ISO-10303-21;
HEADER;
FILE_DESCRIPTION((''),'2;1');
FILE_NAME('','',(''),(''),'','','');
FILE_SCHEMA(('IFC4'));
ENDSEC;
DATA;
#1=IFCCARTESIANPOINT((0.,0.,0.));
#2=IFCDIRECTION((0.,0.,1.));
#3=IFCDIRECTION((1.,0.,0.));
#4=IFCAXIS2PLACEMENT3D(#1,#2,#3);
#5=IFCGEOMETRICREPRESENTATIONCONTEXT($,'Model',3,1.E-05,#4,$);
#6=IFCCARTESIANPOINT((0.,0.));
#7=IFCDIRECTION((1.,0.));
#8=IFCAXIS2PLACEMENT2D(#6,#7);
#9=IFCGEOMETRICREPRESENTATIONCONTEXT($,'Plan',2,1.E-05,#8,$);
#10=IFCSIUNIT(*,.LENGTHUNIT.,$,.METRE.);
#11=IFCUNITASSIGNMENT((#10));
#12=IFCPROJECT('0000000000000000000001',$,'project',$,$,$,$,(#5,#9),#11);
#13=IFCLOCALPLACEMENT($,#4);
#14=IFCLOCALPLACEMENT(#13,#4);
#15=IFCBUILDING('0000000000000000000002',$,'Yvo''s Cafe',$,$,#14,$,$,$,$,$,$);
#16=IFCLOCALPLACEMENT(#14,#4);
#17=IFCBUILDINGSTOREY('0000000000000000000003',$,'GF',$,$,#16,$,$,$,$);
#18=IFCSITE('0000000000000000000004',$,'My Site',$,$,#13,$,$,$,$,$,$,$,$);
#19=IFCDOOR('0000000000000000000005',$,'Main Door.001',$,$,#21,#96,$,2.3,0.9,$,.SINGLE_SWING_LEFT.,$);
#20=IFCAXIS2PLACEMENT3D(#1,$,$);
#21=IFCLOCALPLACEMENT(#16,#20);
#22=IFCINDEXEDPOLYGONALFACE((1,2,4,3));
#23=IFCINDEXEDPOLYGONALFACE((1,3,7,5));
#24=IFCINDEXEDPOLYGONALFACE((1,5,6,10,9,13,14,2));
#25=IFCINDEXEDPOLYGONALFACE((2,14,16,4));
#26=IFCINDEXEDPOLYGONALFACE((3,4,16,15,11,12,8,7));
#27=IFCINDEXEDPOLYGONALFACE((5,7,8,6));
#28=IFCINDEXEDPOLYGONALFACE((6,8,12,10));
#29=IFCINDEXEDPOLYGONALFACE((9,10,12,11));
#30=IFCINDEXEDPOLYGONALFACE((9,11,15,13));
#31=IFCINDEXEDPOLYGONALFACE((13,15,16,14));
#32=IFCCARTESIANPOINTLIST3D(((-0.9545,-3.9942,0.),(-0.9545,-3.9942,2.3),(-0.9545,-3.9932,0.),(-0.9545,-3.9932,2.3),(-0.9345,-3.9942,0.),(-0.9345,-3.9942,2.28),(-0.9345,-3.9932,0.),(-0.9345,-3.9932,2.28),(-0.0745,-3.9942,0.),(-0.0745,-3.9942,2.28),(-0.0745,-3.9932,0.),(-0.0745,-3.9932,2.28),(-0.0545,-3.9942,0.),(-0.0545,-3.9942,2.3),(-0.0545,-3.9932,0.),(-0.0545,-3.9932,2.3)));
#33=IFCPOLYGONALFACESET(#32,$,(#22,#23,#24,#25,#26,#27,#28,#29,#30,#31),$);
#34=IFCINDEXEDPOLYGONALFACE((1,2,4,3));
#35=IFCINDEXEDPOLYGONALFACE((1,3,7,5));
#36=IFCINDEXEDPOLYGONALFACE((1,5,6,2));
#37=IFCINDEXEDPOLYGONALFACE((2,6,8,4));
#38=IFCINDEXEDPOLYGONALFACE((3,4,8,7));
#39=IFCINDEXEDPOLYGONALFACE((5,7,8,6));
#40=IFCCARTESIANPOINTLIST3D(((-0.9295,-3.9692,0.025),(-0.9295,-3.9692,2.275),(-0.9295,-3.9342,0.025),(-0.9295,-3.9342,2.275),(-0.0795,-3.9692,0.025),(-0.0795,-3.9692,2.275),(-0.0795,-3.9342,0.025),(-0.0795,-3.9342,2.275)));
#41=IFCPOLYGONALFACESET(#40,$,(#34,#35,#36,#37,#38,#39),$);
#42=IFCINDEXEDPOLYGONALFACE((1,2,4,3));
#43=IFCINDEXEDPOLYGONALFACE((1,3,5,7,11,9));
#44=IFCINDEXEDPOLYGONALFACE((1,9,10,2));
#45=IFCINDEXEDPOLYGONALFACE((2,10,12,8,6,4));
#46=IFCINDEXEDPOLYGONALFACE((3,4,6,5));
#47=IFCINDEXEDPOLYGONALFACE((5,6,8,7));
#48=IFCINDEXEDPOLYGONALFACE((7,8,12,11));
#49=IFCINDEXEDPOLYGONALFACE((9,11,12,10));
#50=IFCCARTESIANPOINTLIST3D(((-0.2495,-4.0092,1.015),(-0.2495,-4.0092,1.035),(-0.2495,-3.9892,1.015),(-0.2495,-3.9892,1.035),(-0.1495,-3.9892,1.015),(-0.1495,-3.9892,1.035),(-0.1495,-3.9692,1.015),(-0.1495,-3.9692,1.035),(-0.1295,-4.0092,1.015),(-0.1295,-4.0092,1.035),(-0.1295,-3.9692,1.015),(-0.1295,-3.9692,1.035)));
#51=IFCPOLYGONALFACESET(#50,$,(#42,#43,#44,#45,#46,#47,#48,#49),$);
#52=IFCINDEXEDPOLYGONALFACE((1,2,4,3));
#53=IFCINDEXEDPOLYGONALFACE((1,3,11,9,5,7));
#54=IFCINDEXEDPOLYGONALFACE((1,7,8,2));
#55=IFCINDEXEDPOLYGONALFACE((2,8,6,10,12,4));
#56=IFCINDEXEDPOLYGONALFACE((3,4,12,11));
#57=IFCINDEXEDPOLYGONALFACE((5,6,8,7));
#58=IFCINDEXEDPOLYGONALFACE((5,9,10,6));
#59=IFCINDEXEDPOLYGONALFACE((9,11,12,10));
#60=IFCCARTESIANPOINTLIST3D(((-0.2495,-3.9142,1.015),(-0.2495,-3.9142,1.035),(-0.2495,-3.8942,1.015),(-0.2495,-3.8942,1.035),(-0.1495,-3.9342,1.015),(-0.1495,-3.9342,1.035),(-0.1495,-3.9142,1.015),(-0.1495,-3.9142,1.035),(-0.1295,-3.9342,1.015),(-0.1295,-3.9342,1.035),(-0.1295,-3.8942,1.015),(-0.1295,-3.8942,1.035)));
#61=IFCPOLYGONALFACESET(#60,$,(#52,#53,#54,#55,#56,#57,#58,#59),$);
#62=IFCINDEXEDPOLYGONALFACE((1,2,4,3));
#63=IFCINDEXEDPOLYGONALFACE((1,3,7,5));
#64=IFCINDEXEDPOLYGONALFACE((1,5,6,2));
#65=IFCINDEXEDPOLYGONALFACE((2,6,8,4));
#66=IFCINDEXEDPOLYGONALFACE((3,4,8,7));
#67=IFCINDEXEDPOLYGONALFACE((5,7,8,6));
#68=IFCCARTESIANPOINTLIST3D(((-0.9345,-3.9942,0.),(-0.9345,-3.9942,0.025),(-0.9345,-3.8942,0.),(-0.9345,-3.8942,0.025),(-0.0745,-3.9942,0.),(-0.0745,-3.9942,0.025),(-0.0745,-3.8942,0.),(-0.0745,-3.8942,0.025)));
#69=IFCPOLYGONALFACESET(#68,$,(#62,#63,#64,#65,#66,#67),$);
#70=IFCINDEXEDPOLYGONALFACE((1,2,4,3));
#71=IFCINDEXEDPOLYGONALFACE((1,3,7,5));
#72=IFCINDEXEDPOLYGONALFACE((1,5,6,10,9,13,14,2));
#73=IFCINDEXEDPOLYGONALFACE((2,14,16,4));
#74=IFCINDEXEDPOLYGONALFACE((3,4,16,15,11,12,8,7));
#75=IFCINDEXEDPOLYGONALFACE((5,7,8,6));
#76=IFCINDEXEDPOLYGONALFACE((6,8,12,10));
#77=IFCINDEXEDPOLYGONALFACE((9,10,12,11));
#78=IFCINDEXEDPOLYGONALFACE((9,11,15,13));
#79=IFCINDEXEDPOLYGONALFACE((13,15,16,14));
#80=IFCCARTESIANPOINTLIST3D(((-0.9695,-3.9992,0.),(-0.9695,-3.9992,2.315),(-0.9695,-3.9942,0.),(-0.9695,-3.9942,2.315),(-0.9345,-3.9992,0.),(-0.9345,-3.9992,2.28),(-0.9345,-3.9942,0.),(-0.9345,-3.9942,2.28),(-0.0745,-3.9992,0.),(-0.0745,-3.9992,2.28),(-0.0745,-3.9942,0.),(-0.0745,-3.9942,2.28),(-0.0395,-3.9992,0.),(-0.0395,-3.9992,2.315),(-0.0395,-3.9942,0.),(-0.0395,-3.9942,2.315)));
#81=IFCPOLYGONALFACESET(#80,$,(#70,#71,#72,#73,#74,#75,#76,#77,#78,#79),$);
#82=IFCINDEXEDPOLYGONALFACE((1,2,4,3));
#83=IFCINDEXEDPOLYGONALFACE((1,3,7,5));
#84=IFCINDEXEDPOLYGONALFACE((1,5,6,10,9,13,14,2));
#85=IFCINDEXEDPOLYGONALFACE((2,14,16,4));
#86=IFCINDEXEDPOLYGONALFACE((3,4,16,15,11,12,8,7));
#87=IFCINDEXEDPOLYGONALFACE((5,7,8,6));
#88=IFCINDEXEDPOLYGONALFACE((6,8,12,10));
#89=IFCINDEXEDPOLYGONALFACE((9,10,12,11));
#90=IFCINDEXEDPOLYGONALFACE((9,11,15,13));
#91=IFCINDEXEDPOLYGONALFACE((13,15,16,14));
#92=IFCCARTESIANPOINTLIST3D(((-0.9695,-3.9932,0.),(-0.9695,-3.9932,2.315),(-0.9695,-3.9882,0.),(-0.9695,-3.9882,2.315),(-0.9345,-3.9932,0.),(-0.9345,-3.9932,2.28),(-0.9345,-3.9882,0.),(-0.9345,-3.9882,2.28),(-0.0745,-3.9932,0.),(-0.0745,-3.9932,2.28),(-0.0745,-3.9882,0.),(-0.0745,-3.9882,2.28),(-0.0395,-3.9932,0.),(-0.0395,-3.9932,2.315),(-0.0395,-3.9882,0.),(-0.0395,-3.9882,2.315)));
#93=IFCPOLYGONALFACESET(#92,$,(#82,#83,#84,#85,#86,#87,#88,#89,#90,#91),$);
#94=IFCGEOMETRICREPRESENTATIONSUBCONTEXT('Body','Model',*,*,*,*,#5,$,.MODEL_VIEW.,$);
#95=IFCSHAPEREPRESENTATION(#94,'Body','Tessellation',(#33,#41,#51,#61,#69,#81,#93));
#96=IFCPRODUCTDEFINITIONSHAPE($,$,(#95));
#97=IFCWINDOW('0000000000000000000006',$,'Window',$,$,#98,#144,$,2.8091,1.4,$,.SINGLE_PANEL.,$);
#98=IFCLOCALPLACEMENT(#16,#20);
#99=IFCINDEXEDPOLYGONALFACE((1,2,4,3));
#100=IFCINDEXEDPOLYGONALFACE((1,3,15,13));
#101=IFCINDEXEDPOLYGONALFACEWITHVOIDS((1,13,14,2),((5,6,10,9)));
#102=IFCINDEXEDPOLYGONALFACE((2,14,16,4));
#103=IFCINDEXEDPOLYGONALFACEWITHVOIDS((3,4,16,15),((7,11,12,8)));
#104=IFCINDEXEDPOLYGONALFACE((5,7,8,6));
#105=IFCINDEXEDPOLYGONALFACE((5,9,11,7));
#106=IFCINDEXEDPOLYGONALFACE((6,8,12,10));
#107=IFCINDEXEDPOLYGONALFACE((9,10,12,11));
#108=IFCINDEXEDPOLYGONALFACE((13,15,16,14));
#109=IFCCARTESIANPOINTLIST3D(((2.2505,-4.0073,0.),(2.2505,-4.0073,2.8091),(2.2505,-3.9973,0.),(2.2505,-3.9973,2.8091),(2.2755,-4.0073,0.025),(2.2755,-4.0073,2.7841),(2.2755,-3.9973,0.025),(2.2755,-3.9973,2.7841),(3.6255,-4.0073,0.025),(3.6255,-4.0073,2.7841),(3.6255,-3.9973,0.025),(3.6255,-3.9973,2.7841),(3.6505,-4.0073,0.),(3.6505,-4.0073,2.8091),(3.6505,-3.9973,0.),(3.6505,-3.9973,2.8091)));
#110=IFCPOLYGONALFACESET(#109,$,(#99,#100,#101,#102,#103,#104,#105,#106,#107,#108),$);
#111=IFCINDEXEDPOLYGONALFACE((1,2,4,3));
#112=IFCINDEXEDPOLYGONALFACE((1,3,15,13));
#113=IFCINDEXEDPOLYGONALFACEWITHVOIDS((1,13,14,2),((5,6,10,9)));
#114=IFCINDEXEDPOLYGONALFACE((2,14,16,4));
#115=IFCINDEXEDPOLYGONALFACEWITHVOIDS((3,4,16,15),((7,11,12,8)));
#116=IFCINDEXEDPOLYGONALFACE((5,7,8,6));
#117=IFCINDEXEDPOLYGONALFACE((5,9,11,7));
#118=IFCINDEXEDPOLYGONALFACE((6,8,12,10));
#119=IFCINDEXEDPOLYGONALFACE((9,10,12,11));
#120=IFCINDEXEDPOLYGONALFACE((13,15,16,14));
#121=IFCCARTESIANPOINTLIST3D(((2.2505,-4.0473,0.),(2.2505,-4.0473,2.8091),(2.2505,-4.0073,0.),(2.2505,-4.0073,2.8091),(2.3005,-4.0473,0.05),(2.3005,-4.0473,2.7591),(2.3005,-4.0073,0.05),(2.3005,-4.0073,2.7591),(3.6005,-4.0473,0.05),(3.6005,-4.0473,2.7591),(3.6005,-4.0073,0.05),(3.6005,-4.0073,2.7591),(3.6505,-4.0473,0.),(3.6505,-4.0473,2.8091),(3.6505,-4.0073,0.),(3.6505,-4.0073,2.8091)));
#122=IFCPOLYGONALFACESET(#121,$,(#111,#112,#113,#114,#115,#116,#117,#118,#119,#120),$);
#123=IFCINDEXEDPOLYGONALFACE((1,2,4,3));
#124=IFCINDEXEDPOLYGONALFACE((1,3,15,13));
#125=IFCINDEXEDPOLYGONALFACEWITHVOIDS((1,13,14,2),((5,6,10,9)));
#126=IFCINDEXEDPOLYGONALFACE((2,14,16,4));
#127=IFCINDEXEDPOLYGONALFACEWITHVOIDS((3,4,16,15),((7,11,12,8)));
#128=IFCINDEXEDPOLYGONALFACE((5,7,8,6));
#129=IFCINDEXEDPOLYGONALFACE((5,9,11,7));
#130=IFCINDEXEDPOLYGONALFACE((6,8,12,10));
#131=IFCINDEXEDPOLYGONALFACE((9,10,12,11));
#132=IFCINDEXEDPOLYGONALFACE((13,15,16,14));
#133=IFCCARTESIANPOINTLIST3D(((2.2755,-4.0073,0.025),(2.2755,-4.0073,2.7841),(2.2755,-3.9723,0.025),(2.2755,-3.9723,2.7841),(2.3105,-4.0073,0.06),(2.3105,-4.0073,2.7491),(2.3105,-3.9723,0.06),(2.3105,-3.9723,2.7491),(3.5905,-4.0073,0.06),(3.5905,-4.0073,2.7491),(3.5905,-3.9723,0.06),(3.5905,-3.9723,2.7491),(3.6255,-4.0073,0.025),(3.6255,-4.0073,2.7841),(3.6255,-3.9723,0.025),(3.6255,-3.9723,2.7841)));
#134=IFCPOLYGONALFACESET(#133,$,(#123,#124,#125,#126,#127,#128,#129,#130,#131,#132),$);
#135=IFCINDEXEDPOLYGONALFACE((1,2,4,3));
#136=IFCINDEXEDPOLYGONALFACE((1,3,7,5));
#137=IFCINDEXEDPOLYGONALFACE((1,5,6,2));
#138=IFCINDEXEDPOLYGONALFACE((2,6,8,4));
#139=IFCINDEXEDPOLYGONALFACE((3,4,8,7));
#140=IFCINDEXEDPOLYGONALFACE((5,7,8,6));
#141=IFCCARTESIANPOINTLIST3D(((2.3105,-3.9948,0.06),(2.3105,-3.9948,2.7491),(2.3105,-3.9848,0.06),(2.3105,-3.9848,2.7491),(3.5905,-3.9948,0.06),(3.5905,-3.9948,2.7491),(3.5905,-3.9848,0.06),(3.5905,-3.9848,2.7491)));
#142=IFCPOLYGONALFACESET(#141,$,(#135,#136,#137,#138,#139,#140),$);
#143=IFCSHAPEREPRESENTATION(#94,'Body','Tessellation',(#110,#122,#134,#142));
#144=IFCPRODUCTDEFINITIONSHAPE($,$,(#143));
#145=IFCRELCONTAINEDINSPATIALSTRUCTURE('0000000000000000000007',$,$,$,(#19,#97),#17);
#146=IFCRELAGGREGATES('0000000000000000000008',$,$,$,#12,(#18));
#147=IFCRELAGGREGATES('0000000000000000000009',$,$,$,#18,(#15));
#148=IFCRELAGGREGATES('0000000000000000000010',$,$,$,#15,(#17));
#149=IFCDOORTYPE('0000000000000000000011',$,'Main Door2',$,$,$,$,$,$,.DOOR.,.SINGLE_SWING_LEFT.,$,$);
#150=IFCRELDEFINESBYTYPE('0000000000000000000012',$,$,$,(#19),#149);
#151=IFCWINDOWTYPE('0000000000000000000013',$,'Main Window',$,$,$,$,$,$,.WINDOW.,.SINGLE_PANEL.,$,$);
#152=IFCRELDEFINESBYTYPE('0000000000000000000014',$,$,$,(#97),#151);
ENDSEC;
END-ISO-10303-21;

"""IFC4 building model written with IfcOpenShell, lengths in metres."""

from ifc_helpers import new_model, entity, si_unit, frame, origin_with_axes, origin_2d_with_axis, place, context, subcontext, project, spatial, line, indexed_curve, outline, extrude, shape, source, transform, mapped, type_object, type_shapes, element, save


model = new_model("IFC4")

# Units and contexts
model_context = context("Model", 3, precision=1e-05, world=origin_with_axes())
plan_context = context("Plan", 2, precision=1e-05, world=origin_2d_with_axis())
body_context_1 = subcontext(model_context, "Body", "Model", "MODEL_VIEW")
body_context_2 = subcontext(plan_context, "Body", "Plan", "PLAN_VIEW")
ifc_project = project(units=[si_unit("LENGTHUNIT", "METRE")], contexts=[model_context, plan_context])

# Site, building, storey
site_placement = place(None, origin_with_axes())
site = spatial("IfcSite", under=ifc_project, at=site_placement, Name="My Site")
building_placement = place(site_placement, origin_with_axes())
building = spatial("IfcBuilding", under=site, at=building_placement, Name="Yvo's Cafe")
storey_placement = place(building_placement, origin_with_axes())
storey = spatial("IfcBuildingStorey", under=building, at=storey_placement, Name="GF")

# Door
door_type_1 = type_object("IfcDoorType", Name="Main Door2", OperationType="SINGLE_SWING_LEFT", PredefinedType="DOOR")
shared_shape_1 = source(origin_with_axes(), body_context_1, "Body", "SweptSolid", [
    extrude(outline(indexed_curve([(0.0, 0.0), (0.0, 2.3), (0.9, 2.3), (0.9, 0.0), (0.88, 0.0), (0.88, 2.28), (0.02, 2.28), (0.02, 0.0)], segments=[line(1, 2, 3, 4, 5, 6, 7, 8, 1)])), frame((0.0, 0.0, 0.0), z_axis=(0.0, -1.0, 0.0), x_axis=(1.0, 0.0, 0.0)), (0.0, 0.0, -1.0), 0.001),
    extrude(outline(indexed_curve([(0.0, 0.0), (0.85, 0.0), (0.85, 0.035), (0.0, 0.035)], segments=[line(1, 2, 3, 4, 1)])), frame((0.025, 0.025, 0.025), z_axis=(0.0, 0.0, 1.0), x_axis=(1.0, 0.0, 0.0)), (0.0, 0.0, 1.0), 2.25),
    extrude(outline(indexed_curve([(0.0, 0.0), (0.0, -0.04), (-0.12, -0.04), (-0.12, -0.02), (-0.02, -0.02), (-0.02, 0.0)], segments=[line(1, 2, 3, 4, 5, 6, 1)])), frame((0.825, 0.025, 1.015), z_axis=(0.0, 0.0, 1.0), x_axis=(1.0, 0.0, 0.0)), (0.0, 0.0, 1.0), 0.02),
    extrude(outline(indexed_curve([(0.0, 0.0), (0.0, 0.04), (-0.12, 0.04), (-0.12, 0.02), (-0.02, 0.02), (-0.02, 0.0)], segments=[line(1, 2, 3, 4, 5, 6, 1)])), frame((0.825, 0.06, 1.015), z_axis=(0.0, 0.0, 1.0), x_axis=(1.0, 0.0, 0.0)), (0.0, 0.0, 1.0), 0.02),
    extrude(outline(indexed_curve([(0.0, 0.0), (0.86, 0.0), (0.86, 0.1), (0.0, 0.1)], segments=[line(1, 2, 3, 4, 1)])), frame((0.02, 0.0, 0.0), z_axis=(0.0, 0.0, 1.0), x_axis=(1.0, 0.0, 0.0)), (0.0, 0.0, 1.0), 0.025),
    extrude(outline(indexed_curve([(0.0, 0.0), (0.0, 2.315), (0.93, 2.315), (0.93, 0.0), (0.895, 0.0), (0.895, 2.28), (0.035, 2.28), (0.035, 0.0)], segments=[line(1, 2, 3, 4, 5, 6, 7, 8, 1)])), frame((-0.015, -0.005, 0.0), z_axis=(0.0, -1.0, 0.0), x_axis=(1.0, 0.0, 0.0)), (0.0, 0.0, -1.0), 0.005),
    extrude(outline(indexed_curve([(0.0, 0.0), (0.0, 2.315), (0.93, 2.315), (0.93, 0.0), (0.895, 0.0), (0.895, 2.28), (0.035, 2.28), (0.035, 0.0)], segments=[line(1, 2, 3, 4, 5, 6, 7, 8, 1)])), frame((-0.015, 0.001, 0.0), z_axis=(0.0, -1.0, 0.0), x_axis=(1.0, 0.0, 0.0)), (0.0, 0.0, -1.0), 0.005),
])
shared_shape_2 = source(origin_with_axes(), body_context_2, "Body", "Curve2D", [
    entity("IfcIndexedPolyCurve", entity("IfcCartesianPointList2D", [[0.0, 0.0], [0.02, 0.0], [0.02, 0.001], [0.0, 0.001]]), [entity("IfcLineIndex", [1, 2, 3, 4, 1])]),
    entity("IfcIndexedPolyCurve", entity("IfcCartesianPointList2D", [[0.9, 0.0], [0.88, 0.0], [0.88, 0.001], [0.9, 0.001]]), [entity("IfcLineIndex", [1, 2, 3, 4, 1])]),
    entity("IfcTrimmedCurve", entity("IfcEllipse", entity("IfcAxis2Placement2D", entity("IfcCartesianPoint", [0.06, 0.001]), entity("IfcDirection", [1.0, 0.0])), 0.815, 0.85), [entity("IfcCartesianPoint", [0.875, 0.001])], [entity("IfcCartesianPoint", [0.06, 0.851])], True, "CARTESIAN"),
    entity("IfcIndexedPolyCurve", entity("IfcCartesianPointList2D", [[0.025, 0.001], [0.06, 0.001], [0.06, 0.851], [0.025, 0.851]]), [entity("IfcLineIndex", [1, 2, 3, 4, 1])]),
])
type_shapes(door_type_1, [shared_shape_1, shared_shape_2])
door_1_placement = place(storey_placement, frame((-0.9545, -3.9942, 0.0), z_axis=(0.0, 0.0, 1.0), x_axis=(1.0, 0.0, 0.0)))
element("IfcDoor", 1, at=door_1_placement, inside=storey, type_object=door_type_1, Name="Main Door.001", OperationType="SINGLE_SWING_LEFT", OverallHeight=2.3, OverallWidth=0.9, shapes=[
    shape(body_context_1, "Body", "MappedRepresentation", [mapped(shared_shape_1, transform((0.0, 0.0, 0.0), x_axis=(1.0, 0.0, 0.0), y_axis=(0.0, 1.0, 0.0), z_axis=(0.0, 0.0, 1.0), scale=1.0))]),
    shape(body_context_2, "Body", "MappedRepresentation", [mapped(shared_shape_2, transform((0.0, 0.0, 0.0), x_axis=(1.0, 0.0, 0.0), y_axis=(0.0, 1.0, 0.0), z_axis=(0.0, 0.0, 1.0), scale=1.0))]),
])

# Window
window_type_1 = type_object("IfcWindowType", Name="Main Window", PartitioningType="SINGLE_PANEL", PredefinedType="WINDOW")
shared_shape_3 = source(origin_with_axes(), body_context_1, "Body", "SweptSolid", [
    extrude(outline(indexed_curve([(0.0, 0.0), (1.4, 0.0), (1.4, 2.8091), (0.0, 2.8091)], segments=[line(1, 2, 3, 4, 1)]), holes=[indexed_curve([(0.025, 0.025), (1.375, 0.025), (1.375, 2.7841), (0.025, 2.7841)], segments=[line(1, 2, 3, 4, 1)])]), frame((0.0, 0.09, 0.0), z_axis=(0.0, -1.0, 0.0), x_axis=(1.0, 0.0, 0.0)), (0.0, 0.0, -1.0), 0.01),
    extrude(outline(indexed_curve([(0.0, 0.0), (1.4, 0.0), (1.4, 2.8091), (0.0, 2.8091)], segments=[line(1, 2, 3, 4, 1)]), holes=[indexed_curve([(0.05, 0.05), (1.35, 0.05), (1.35, 2.7591), (0.05, 2.7591)], segments=[line(1, 2, 3, 4, 1)])]), frame((0.0, 0.05, 0.0), z_axis=(0.0, -1.0, 0.0), x_axis=(1.0, 0.0, 0.0)), (0.0, 0.0, -1.0), 0.04),
    extrude(outline(indexed_curve([(0.0, 0.0), (1.35, 0.0), (1.35, 2.7591), (0.0, 2.7591)], segments=[line(1, 2, 3, 4, 1)]), holes=[indexed_curve([(0.035, 0.035), (1.315, 0.035), (1.315, 2.7241), (0.035, 2.7241)], segments=[line(1, 2, 3, 4, 1)])]), frame((0.025, 0.09, 0.025), z_axis=(0.0, -1.0, 0.0), x_axis=(1.0, 0.0, 0.0)), (0.0, 0.0, -1.0), 0.035),
    extrude(outline(indexed_curve([(0.035, 0.035), (1.315, 0.035), (1.315, 2.7241), (0.035, 2.7241)], segments=[line(1, 2, 3, 4, 1)])), frame((0.025, 0.1025, 0.025), z_axis=(0.0, -1.0, 0.0), x_axis=(1.0, 0.0, 0.0)), (0.0, 0.0, -1.0), 0.01),
])
shared_shape_4 = source(origin_with_axes(), body_context_2, "Body", "Curve2D", [
    entity("IfcIndexedPolyCurve", entity("IfcCartesianPointList2D", [[0.05, 0.05], [1.35, 0.05]])),
    entity("IfcIndexedPolyCurve", entity("IfcCartesianPointList2D", [[0.0, 0.1], [0.025, 0.1], [0.025, 0.09], [0.05, 0.09], [0.05, 0.05], [0.0, 0.05]]), [entity("IfcLineIndex", [1, 2, 3, 4, 5, 6, 1])]),
    entity("IfcIndexedPolyCurve", entity("IfcCartesianPointList2D", [[1.4, 0.1], [1.375, 0.1], [1.375, 0.09], [1.35, 0.09], [1.35, 0.05], [1.4, 0.05]]), [entity("IfcLineIndex", [1, 2, 3, 4, 5, 6, 1])]),
    entity("IfcIndexedPolyCurve", entity("IfcCartesianPointList2D", [[0.025, 0.09], [0.06, 0.09], [0.06, 0.125], [0.025, 0.125]]), [entity("IfcLineIndex", [1, 2, 3, 4, 1])]),
    entity("IfcIndexedPolyCurve", entity("IfcCartesianPointList2D", [[1.375, 0.09], [1.34, 0.09], [1.34, 0.125], [1.375, 0.125]]), [entity("IfcLineIndex", [1, 2, 3, 4, 1])]),
    entity("IfcIndexedPolyCurve", entity("IfcCartesianPointList2D", [[0.06, 0.09], [1.34, 0.09]])),
    entity("IfcIndexedPolyCurve", entity("IfcCartesianPointList2D", [[0.06, 0.125], [1.34, 0.125]])),
    entity("IfcIndexedPolyCurve", entity("IfcCartesianPointList2D", [[0.06, 0.1075], [1.34, 0.1075]])),
])
type_shapes(window_type_1, [shared_shape_3, shared_shape_4])
window_1_placement = place(storey_placement, frame((2.2505, -4.0973, 0.0), z_axis=(0.0, 0.0, 1.0), x_axis=(1.0, 0.0, 0.0)))
element("IfcWindow", 2, at=window_1_placement, inside=storey, type_object=window_type_1, Name="Window", OverallHeight=2.8091, OverallWidth=1.4, PartitioningType="SINGLE_PANEL", shapes=[
    shape(body_context_1, "Body", "MappedRepresentation", [mapped(shared_shape_3, transform((0.0, 0.0, 0.0), x_axis=(1.0, 0.0, 0.0), y_axis=(0.0, 1.0, 0.0), z_axis=(0.0, 0.0, 1.0), scale=1.0))]),
    shape(body_context_2, "Body", "MappedRepresentation", [mapped(shared_shape_4, transform((0.0, 0.0, 0.0), x_axis=(1.0, 0.0, 0.0), y_axis=(0.0, 1.0, 0.0), z_axis=(0.0, 0.0, 1.0), scale=1.0))]),
])

save(model, "model.ifc")
